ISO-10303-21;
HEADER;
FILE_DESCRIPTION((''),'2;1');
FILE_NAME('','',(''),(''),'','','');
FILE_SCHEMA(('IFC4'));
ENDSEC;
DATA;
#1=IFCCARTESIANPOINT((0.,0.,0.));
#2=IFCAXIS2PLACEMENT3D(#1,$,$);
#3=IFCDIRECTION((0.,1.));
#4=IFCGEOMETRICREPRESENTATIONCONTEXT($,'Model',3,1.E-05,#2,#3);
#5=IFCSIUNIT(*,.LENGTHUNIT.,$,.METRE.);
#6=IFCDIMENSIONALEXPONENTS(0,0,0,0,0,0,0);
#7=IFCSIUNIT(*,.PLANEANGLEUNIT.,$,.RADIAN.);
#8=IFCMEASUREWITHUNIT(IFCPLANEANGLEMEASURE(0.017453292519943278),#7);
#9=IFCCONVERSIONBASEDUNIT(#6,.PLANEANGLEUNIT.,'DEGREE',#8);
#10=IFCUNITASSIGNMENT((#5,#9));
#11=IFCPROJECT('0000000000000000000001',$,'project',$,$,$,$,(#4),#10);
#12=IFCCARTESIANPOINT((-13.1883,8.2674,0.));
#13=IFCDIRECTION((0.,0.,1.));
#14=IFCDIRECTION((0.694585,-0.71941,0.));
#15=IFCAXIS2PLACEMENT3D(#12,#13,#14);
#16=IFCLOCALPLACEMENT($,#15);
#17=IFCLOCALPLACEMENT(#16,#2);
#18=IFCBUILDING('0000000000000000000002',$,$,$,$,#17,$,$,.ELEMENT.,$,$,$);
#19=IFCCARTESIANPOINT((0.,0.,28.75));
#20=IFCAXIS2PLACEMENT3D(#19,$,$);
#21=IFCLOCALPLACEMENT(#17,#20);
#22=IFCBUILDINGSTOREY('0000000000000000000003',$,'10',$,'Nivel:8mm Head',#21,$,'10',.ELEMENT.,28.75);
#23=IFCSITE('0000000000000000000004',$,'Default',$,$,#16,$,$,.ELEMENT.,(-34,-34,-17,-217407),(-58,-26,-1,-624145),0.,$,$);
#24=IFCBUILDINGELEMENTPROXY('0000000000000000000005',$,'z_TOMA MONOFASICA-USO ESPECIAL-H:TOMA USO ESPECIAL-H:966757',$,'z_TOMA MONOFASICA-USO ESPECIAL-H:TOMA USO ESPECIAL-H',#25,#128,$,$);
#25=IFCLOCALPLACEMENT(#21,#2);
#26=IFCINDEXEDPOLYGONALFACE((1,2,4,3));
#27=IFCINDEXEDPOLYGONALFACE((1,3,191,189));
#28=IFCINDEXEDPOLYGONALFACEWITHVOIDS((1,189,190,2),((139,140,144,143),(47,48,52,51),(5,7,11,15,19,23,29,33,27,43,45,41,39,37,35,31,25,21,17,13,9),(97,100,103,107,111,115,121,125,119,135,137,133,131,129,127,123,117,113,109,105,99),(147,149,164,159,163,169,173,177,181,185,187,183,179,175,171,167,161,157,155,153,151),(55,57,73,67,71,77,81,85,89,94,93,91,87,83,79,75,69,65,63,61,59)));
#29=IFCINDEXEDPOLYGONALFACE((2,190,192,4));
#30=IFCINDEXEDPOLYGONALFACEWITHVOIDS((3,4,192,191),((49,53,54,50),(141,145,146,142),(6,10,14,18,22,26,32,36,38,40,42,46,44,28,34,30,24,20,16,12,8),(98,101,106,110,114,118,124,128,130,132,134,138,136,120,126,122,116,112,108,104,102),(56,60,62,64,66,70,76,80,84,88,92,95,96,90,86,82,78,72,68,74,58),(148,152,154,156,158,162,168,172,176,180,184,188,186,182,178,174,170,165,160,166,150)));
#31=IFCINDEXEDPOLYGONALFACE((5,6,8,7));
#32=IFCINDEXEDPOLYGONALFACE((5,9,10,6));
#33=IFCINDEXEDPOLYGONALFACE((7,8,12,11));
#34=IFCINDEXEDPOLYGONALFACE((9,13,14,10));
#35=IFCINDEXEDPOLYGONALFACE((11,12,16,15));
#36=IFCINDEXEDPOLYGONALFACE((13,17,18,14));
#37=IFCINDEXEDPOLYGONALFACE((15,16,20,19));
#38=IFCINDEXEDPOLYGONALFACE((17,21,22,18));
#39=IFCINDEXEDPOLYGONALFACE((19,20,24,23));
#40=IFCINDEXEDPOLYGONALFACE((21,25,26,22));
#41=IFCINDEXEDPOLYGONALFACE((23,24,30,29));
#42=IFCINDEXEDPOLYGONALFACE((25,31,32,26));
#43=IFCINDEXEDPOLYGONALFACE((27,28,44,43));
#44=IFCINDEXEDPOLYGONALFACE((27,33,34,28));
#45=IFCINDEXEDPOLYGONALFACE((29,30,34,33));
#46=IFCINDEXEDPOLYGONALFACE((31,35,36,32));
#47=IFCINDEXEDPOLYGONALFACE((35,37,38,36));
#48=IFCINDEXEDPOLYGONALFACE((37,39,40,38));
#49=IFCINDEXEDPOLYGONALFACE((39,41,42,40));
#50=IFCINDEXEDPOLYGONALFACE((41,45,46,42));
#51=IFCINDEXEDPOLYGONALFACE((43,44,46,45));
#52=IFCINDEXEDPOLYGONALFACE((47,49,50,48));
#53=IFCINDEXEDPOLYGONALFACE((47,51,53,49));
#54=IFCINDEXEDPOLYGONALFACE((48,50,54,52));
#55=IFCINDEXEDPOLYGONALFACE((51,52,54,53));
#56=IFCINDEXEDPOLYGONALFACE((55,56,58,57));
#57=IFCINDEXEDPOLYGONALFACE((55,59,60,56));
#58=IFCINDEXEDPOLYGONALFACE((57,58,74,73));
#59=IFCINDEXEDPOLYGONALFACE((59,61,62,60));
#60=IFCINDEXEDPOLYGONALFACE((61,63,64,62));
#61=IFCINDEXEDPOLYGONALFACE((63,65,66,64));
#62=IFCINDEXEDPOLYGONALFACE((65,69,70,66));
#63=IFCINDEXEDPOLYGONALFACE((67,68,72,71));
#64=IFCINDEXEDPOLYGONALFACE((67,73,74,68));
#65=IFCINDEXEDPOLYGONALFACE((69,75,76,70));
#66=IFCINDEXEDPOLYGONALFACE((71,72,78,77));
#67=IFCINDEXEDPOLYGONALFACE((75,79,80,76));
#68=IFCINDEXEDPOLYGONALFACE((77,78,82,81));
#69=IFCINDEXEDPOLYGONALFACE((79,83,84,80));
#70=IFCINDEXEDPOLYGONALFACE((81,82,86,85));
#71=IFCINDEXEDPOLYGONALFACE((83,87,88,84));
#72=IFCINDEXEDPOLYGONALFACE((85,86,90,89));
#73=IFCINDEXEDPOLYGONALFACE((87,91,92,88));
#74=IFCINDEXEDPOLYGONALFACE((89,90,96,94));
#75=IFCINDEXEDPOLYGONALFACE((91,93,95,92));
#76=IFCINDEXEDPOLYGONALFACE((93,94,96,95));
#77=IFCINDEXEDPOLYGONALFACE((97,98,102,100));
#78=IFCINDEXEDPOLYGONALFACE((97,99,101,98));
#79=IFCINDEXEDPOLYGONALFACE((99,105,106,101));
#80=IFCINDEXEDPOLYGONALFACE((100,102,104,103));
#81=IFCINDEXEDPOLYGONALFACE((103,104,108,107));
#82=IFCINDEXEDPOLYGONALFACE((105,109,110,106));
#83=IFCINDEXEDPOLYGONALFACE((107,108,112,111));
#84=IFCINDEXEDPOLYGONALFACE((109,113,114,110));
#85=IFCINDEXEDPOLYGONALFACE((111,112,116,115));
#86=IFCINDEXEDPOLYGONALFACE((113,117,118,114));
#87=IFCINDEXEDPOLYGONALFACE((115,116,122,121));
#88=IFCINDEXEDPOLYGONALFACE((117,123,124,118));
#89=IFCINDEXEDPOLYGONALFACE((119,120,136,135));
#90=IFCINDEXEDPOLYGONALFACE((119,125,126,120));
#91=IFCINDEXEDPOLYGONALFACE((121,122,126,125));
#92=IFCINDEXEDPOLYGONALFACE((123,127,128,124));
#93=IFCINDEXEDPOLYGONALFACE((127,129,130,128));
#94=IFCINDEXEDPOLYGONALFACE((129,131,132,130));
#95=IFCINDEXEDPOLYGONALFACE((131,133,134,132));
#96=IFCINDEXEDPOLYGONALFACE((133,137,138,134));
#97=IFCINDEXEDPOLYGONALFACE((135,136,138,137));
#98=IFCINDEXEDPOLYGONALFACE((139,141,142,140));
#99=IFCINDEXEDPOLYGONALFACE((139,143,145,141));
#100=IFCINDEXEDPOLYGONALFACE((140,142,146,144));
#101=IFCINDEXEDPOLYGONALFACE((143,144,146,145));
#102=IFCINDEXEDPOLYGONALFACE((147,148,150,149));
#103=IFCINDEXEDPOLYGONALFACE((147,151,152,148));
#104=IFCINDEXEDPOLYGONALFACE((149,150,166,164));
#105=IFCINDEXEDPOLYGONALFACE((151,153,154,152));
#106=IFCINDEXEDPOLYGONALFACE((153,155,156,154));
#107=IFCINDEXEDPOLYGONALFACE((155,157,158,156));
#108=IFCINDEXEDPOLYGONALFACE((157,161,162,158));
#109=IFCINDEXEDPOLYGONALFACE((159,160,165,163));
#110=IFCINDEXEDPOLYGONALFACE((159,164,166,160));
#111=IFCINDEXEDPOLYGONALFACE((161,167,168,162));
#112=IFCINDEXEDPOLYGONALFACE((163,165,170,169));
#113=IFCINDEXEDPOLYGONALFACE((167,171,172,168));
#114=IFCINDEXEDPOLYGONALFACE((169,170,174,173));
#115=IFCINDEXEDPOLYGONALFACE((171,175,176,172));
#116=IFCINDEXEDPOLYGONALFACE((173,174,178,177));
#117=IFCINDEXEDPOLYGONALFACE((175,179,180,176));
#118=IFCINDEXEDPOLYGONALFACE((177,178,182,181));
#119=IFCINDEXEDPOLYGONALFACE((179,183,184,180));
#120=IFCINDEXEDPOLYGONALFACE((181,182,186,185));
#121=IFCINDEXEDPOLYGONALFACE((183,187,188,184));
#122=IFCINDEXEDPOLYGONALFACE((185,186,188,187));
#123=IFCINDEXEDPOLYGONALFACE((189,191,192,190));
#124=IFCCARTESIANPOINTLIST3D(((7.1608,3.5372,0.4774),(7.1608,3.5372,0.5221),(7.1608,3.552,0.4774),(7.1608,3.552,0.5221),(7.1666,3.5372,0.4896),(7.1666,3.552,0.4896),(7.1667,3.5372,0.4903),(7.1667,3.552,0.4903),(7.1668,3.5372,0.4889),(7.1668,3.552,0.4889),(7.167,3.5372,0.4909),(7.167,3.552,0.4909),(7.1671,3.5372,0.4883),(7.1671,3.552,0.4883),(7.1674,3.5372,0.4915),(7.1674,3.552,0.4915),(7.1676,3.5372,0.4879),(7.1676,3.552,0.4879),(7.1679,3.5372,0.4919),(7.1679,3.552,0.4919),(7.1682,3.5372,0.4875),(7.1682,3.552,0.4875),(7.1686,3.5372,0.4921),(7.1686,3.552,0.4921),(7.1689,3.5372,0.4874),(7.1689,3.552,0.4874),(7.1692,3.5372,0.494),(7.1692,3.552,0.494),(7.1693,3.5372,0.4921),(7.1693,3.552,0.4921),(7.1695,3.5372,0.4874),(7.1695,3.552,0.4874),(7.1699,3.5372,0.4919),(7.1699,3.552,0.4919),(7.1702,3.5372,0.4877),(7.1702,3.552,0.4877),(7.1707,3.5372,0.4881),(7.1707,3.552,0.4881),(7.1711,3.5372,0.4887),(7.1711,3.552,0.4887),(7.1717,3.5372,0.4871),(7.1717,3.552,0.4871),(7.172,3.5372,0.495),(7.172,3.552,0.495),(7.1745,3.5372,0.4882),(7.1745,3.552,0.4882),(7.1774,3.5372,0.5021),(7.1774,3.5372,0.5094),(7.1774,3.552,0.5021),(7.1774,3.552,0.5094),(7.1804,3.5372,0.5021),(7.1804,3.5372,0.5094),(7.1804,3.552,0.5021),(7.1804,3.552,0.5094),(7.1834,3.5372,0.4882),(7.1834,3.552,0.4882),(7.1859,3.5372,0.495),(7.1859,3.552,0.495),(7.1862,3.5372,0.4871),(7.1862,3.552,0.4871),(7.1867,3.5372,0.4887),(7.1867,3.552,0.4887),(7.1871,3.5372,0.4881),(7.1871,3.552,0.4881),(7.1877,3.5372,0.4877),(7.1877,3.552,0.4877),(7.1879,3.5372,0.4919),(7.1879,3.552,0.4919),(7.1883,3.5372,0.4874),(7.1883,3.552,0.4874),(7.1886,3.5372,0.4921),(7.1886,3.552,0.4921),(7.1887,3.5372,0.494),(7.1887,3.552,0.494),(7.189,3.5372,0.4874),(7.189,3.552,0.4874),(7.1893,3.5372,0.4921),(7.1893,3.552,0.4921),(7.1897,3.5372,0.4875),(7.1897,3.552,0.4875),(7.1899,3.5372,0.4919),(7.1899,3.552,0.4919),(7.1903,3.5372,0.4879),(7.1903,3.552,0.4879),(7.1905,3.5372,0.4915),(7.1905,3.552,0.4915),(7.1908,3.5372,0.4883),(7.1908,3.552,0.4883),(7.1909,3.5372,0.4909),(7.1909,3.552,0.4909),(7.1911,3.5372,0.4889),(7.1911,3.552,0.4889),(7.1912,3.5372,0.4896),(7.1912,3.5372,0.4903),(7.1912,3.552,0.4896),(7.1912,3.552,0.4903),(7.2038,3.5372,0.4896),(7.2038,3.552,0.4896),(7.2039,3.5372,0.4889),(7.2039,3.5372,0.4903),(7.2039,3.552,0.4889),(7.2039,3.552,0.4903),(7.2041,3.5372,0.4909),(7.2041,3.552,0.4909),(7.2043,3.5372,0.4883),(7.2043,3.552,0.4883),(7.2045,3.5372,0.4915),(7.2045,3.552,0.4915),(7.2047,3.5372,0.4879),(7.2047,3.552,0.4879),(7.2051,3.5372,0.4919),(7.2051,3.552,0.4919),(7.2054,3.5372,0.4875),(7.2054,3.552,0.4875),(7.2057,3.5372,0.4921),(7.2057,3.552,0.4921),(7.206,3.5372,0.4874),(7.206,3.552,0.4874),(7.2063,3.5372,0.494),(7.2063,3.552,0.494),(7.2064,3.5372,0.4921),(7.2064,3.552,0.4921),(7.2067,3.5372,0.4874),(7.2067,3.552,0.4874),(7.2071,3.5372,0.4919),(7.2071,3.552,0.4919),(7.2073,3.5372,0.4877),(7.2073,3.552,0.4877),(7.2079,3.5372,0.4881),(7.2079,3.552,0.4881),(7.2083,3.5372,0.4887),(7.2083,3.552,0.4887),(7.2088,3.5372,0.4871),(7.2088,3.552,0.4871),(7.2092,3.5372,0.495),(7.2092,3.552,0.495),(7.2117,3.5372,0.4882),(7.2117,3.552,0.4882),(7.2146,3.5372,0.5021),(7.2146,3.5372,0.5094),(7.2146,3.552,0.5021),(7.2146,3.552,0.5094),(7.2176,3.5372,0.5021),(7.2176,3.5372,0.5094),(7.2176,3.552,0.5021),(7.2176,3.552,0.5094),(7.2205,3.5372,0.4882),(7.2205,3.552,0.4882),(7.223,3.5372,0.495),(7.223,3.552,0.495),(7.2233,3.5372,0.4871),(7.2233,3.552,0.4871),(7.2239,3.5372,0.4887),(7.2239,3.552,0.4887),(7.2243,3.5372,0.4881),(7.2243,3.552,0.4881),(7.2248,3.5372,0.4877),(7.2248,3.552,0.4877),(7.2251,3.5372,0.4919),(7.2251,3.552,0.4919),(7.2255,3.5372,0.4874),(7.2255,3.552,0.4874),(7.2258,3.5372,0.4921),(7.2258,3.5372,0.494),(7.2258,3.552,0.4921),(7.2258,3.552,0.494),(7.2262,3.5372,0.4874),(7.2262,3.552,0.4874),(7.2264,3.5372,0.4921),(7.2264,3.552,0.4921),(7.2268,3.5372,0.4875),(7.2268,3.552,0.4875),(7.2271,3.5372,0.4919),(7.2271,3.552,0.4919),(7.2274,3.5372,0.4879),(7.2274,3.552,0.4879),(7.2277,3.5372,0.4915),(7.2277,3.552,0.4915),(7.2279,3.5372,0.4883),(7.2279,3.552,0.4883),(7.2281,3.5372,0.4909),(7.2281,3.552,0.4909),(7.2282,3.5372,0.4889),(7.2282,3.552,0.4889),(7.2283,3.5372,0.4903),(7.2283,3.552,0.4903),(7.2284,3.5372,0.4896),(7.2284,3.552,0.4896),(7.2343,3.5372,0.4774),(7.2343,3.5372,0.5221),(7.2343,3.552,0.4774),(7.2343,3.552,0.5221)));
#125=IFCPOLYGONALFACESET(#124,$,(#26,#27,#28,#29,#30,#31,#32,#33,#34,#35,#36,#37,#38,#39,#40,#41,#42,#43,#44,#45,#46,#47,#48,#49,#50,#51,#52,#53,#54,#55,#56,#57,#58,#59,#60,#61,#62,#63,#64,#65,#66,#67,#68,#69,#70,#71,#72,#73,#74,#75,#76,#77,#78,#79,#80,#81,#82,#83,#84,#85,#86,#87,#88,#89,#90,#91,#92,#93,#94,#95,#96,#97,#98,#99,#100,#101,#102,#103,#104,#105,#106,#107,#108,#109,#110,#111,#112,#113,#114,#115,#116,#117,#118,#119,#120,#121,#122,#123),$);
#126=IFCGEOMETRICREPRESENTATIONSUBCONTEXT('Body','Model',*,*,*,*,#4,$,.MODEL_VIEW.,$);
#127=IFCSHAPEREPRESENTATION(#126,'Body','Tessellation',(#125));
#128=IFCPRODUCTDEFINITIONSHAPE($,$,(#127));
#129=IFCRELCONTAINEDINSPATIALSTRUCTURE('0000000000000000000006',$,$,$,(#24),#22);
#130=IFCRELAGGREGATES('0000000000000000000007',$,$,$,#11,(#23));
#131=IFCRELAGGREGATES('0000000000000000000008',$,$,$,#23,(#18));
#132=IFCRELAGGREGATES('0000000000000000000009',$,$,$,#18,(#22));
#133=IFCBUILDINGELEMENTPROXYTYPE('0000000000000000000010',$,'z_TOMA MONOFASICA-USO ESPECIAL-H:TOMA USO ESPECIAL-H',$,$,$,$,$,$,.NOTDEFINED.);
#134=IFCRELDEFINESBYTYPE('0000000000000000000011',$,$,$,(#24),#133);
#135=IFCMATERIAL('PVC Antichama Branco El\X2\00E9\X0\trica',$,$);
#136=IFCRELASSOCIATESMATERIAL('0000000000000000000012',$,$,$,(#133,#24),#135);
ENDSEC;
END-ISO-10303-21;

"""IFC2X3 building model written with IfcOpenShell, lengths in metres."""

from ifc_helpers import new_model, entity, si_unit, converted_unit, direction, frame, frame_2d, origin, place, context, subcontext, project, spatial, polyline, circle_curve, parameter, trimmed, segment, composite_curve, outline, extrude, source, transform, mapped, material, type_object, type_shapes, element, save


model = new_model("IFC2X3")

# Units and contexts
model_context = context("Model", 3, precision=1e-05, world=origin(), true_north=direction((0.0, 1.0)))
body_context = subcontext(model_context, "Body", "Model", "MODEL_VIEW")
ifc_project = project(units=[si_unit("LENGTHUNIT", "METRE"), converted_unit("PLANEANGLEUNIT", "DEGREE", entity("IfcPlaneAngleMeasure", 0.017453292519943278), si_unit("PLANEANGLEUNIT", "RADIAN"), dimensions=[0, 0, 0, 0, 0, 0, 0])], contexts=[model_context])

# Site, building, storey
site_placement = place(None, frame((-13.1883, 8.2674, 0.0), z_axis=(0.0, 0.0, 1.0), x_axis=(0.694585, -0.71941, 0.0)))
site = spatial("IfcSite", under=ifc_project, at=site_placement, Name="Default", CompositionType="ELEMENT", RefLatitude=(-34, -34, -17, -217407), RefLongitude=(-58, -26, -1, -624145), RefElevation=0.0)
building_placement = place(site_placement, origin())
building = spatial("IfcBuilding", under=site, at=building_placement, CompositionType="ELEMENT")
storey_placement = place(building_placement, frame((0.0, 0.0, 28.75)))
storey = spatial("IfcBuildingStorey", under=building, at=storey_placement, Name="10", ObjectType="Nivel:8mm Head", LongName="10", CompositionType="ELEMENT", Elevation=28.75)

# Building element proxy
ifc_material_1 = material(Name="PVC Antichama Branco Elétrica")
building_element_proxy_type_1 = type_object("IfcBuildingElementProxyType", Name="z_TOMA MONOFASICA-USO ESPECIAL-H:TOMA USO ESPECIAL-H", PredefinedType="NOTDEFINED", material=ifc_material_1)
shared_shape_1 = source(origin(), body_context, "Body", "SweptSolid", [
    extrude(outline(polyline([(-0.0368, -0.0223), (0.0368, -0.0223), (0.0368, 0.0223), (-0.0368, 0.0223), (-0.0368, -0.0223)]), holes=[composite_curve([segment(polyline([(0.0141, 0.0115), (0.0116, 0.0047)]), True, "CONTINUOUS"), segment(polyline([(0.0116, 0.0047), (0.0088, 0.0057)]), True, "CONTINUOUS"), segment(polyline([(0.0088, 0.0057), (0.0096, 0.0078)]), True, "CONTINUOUS"), segment(trimmed(circle_curve(frame_2d((0.0087, 0.0099), x_axis=(1.0, 0.0)), 0.0024), [parameter(27.118901)], [parameter(292.881099)], True, "PARAMETER"), False, "CONTINUOUS"), segment(polyline([(0.0108, 0.011), (0.0113, 0.0126)]), True, "CONTINUOUS"), segment(polyline([(0.0113, 0.0126), (0.0141, 0.0115)]), True, "CONTINUOUS")], self_intersect=False), composite_curve([segment(polyline([(0.0255, 0.0047), (0.023, 0.0115)]), True, "CONTINUOUS"), segment(polyline([(0.023, 0.0115), (0.0258, 0.0126)]), True, "CONTINUOUS"), segment(polyline([(0.0258, 0.0126), (0.0264, 0.011)]), True, "CONTINUOUS"), segment(trimmed(circle_curve(frame_2d((0.0285, 0.0099), x_axis=(1.0, 0.0)), 0.0024), [parameter(247.118901)], [parameter(152.881099)], True, "PARAMETER"), False, "CONTINUOUS"), segment(polyline([(0.0276, 0.0078), (0.0283, 0.0057)]), True, "CONTINUOUS"), segment(polyline([(0.0283, 0.0057), (0.0255, 0.0047)]), True, "CONTINUOUS")], self_intersect=False), polyline([(0.0201, -0.0024), (0.0201, -0.0097), (0.0171, -0.0097), (0.0171, -0.0024), (0.0201, -0.0024)]), composite_curve([segment(polyline([(-0.0141, 0.0115), (-0.0113, 0.0126)]), True, "CONTINUOUS"), segment(polyline([(-0.0113, 0.0126), (-0.0108, 0.011)]), True, "CONTINUOUS"), segment(trimmed(circle_curve(frame_2d((-0.0087, 0.0099), x_axis=(1.0, 0.0)), 0.0024), [parameter(247.118901)], [parameter(152.881099)], True, "PARAMETER"), False, "CONTINUOUS"), segment(polyline([(-0.0096, 0.0078), (-0.0088, 0.0057)]), True, "CONTINUOUS"), segment(polyline([(-0.0088, 0.0057), (-0.0116, 0.0047)]), True, "CONTINUOUS"), segment(polyline([(-0.0116, 0.0047), (-0.0141, 0.0115)]), True, "CONTINUOUS")], self_intersect=False), composite_curve([segment(polyline([(-0.0255, 0.0047), (-0.0283, 0.0057)]), True, "CONTINUOUS"), segment(polyline([(-0.0283, 0.0057), (-0.0276, 0.0078)]), True, "CONTINUOUS"), segment(trimmed(circle_curve(frame_2d((-0.0285, 0.0099), x_axis=(1.0, 0.0)), 0.0024), [parameter(27.118901)], [parameter(292.881099)], True, "PARAMETER"), False, "CONTINUOUS"), segment(polyline([(-0.0264, 0.011), (-0.0258, 0.0126)]), True, "CONTINUOUS"), segment(polyline([(-0.0258, 0.0126), (-0.023, 0.0115)]), True, "CONTINUOUS"), segment(polyline([(-0.023, 0.0115), (-0.0255, 0.0047)]), True, "CONTINUOUS")], self_intersect=False), polyline([(-0.0201, -0.0024), (-0.0171, -0.0024), (-0.0171, -0.0097), (-0.0201, -0.0097), (-0.0201, -0.0024)])]), frame((0.0, -0.005, 0.0223), z_axis=(0.0, 1.0, 0.0), x_axis=(1.0, 0.0, 0.0)), (0.0, 0.0, 1.0), 0.0148),
])
type_shapes(building_element_proxy_type_1, [shared_shape_1])
proxy_1_placement = place(storey_placement, frame((7.1975, 3.547, 0.4774), z_axis=(0.0, 0.0, 1.0), x_axis=(-1.0, 0.0, 0.0)))
element("IfcBuildingElementProxy", 1, at=proxy_1_placement, inside=storey, type_object=building_element_proxy_type_1, material=ifc_material_1, Name="z_TOMA MONOFASICA-USO ESPECIAL-H:TOMA USO ESPECIAL-H:966757", ObjectType="z_TOMA MONOFASICA-USO ESPECIAL-H:TOMA USO ESPECIAL-H", context=body_context, shape_type="MappedRepresentation", body=[
    mapped(shared_shape_1, transform((0.0, 0.0, 0.0), scale=1.0)),
])

save(model, "model.ifc")
